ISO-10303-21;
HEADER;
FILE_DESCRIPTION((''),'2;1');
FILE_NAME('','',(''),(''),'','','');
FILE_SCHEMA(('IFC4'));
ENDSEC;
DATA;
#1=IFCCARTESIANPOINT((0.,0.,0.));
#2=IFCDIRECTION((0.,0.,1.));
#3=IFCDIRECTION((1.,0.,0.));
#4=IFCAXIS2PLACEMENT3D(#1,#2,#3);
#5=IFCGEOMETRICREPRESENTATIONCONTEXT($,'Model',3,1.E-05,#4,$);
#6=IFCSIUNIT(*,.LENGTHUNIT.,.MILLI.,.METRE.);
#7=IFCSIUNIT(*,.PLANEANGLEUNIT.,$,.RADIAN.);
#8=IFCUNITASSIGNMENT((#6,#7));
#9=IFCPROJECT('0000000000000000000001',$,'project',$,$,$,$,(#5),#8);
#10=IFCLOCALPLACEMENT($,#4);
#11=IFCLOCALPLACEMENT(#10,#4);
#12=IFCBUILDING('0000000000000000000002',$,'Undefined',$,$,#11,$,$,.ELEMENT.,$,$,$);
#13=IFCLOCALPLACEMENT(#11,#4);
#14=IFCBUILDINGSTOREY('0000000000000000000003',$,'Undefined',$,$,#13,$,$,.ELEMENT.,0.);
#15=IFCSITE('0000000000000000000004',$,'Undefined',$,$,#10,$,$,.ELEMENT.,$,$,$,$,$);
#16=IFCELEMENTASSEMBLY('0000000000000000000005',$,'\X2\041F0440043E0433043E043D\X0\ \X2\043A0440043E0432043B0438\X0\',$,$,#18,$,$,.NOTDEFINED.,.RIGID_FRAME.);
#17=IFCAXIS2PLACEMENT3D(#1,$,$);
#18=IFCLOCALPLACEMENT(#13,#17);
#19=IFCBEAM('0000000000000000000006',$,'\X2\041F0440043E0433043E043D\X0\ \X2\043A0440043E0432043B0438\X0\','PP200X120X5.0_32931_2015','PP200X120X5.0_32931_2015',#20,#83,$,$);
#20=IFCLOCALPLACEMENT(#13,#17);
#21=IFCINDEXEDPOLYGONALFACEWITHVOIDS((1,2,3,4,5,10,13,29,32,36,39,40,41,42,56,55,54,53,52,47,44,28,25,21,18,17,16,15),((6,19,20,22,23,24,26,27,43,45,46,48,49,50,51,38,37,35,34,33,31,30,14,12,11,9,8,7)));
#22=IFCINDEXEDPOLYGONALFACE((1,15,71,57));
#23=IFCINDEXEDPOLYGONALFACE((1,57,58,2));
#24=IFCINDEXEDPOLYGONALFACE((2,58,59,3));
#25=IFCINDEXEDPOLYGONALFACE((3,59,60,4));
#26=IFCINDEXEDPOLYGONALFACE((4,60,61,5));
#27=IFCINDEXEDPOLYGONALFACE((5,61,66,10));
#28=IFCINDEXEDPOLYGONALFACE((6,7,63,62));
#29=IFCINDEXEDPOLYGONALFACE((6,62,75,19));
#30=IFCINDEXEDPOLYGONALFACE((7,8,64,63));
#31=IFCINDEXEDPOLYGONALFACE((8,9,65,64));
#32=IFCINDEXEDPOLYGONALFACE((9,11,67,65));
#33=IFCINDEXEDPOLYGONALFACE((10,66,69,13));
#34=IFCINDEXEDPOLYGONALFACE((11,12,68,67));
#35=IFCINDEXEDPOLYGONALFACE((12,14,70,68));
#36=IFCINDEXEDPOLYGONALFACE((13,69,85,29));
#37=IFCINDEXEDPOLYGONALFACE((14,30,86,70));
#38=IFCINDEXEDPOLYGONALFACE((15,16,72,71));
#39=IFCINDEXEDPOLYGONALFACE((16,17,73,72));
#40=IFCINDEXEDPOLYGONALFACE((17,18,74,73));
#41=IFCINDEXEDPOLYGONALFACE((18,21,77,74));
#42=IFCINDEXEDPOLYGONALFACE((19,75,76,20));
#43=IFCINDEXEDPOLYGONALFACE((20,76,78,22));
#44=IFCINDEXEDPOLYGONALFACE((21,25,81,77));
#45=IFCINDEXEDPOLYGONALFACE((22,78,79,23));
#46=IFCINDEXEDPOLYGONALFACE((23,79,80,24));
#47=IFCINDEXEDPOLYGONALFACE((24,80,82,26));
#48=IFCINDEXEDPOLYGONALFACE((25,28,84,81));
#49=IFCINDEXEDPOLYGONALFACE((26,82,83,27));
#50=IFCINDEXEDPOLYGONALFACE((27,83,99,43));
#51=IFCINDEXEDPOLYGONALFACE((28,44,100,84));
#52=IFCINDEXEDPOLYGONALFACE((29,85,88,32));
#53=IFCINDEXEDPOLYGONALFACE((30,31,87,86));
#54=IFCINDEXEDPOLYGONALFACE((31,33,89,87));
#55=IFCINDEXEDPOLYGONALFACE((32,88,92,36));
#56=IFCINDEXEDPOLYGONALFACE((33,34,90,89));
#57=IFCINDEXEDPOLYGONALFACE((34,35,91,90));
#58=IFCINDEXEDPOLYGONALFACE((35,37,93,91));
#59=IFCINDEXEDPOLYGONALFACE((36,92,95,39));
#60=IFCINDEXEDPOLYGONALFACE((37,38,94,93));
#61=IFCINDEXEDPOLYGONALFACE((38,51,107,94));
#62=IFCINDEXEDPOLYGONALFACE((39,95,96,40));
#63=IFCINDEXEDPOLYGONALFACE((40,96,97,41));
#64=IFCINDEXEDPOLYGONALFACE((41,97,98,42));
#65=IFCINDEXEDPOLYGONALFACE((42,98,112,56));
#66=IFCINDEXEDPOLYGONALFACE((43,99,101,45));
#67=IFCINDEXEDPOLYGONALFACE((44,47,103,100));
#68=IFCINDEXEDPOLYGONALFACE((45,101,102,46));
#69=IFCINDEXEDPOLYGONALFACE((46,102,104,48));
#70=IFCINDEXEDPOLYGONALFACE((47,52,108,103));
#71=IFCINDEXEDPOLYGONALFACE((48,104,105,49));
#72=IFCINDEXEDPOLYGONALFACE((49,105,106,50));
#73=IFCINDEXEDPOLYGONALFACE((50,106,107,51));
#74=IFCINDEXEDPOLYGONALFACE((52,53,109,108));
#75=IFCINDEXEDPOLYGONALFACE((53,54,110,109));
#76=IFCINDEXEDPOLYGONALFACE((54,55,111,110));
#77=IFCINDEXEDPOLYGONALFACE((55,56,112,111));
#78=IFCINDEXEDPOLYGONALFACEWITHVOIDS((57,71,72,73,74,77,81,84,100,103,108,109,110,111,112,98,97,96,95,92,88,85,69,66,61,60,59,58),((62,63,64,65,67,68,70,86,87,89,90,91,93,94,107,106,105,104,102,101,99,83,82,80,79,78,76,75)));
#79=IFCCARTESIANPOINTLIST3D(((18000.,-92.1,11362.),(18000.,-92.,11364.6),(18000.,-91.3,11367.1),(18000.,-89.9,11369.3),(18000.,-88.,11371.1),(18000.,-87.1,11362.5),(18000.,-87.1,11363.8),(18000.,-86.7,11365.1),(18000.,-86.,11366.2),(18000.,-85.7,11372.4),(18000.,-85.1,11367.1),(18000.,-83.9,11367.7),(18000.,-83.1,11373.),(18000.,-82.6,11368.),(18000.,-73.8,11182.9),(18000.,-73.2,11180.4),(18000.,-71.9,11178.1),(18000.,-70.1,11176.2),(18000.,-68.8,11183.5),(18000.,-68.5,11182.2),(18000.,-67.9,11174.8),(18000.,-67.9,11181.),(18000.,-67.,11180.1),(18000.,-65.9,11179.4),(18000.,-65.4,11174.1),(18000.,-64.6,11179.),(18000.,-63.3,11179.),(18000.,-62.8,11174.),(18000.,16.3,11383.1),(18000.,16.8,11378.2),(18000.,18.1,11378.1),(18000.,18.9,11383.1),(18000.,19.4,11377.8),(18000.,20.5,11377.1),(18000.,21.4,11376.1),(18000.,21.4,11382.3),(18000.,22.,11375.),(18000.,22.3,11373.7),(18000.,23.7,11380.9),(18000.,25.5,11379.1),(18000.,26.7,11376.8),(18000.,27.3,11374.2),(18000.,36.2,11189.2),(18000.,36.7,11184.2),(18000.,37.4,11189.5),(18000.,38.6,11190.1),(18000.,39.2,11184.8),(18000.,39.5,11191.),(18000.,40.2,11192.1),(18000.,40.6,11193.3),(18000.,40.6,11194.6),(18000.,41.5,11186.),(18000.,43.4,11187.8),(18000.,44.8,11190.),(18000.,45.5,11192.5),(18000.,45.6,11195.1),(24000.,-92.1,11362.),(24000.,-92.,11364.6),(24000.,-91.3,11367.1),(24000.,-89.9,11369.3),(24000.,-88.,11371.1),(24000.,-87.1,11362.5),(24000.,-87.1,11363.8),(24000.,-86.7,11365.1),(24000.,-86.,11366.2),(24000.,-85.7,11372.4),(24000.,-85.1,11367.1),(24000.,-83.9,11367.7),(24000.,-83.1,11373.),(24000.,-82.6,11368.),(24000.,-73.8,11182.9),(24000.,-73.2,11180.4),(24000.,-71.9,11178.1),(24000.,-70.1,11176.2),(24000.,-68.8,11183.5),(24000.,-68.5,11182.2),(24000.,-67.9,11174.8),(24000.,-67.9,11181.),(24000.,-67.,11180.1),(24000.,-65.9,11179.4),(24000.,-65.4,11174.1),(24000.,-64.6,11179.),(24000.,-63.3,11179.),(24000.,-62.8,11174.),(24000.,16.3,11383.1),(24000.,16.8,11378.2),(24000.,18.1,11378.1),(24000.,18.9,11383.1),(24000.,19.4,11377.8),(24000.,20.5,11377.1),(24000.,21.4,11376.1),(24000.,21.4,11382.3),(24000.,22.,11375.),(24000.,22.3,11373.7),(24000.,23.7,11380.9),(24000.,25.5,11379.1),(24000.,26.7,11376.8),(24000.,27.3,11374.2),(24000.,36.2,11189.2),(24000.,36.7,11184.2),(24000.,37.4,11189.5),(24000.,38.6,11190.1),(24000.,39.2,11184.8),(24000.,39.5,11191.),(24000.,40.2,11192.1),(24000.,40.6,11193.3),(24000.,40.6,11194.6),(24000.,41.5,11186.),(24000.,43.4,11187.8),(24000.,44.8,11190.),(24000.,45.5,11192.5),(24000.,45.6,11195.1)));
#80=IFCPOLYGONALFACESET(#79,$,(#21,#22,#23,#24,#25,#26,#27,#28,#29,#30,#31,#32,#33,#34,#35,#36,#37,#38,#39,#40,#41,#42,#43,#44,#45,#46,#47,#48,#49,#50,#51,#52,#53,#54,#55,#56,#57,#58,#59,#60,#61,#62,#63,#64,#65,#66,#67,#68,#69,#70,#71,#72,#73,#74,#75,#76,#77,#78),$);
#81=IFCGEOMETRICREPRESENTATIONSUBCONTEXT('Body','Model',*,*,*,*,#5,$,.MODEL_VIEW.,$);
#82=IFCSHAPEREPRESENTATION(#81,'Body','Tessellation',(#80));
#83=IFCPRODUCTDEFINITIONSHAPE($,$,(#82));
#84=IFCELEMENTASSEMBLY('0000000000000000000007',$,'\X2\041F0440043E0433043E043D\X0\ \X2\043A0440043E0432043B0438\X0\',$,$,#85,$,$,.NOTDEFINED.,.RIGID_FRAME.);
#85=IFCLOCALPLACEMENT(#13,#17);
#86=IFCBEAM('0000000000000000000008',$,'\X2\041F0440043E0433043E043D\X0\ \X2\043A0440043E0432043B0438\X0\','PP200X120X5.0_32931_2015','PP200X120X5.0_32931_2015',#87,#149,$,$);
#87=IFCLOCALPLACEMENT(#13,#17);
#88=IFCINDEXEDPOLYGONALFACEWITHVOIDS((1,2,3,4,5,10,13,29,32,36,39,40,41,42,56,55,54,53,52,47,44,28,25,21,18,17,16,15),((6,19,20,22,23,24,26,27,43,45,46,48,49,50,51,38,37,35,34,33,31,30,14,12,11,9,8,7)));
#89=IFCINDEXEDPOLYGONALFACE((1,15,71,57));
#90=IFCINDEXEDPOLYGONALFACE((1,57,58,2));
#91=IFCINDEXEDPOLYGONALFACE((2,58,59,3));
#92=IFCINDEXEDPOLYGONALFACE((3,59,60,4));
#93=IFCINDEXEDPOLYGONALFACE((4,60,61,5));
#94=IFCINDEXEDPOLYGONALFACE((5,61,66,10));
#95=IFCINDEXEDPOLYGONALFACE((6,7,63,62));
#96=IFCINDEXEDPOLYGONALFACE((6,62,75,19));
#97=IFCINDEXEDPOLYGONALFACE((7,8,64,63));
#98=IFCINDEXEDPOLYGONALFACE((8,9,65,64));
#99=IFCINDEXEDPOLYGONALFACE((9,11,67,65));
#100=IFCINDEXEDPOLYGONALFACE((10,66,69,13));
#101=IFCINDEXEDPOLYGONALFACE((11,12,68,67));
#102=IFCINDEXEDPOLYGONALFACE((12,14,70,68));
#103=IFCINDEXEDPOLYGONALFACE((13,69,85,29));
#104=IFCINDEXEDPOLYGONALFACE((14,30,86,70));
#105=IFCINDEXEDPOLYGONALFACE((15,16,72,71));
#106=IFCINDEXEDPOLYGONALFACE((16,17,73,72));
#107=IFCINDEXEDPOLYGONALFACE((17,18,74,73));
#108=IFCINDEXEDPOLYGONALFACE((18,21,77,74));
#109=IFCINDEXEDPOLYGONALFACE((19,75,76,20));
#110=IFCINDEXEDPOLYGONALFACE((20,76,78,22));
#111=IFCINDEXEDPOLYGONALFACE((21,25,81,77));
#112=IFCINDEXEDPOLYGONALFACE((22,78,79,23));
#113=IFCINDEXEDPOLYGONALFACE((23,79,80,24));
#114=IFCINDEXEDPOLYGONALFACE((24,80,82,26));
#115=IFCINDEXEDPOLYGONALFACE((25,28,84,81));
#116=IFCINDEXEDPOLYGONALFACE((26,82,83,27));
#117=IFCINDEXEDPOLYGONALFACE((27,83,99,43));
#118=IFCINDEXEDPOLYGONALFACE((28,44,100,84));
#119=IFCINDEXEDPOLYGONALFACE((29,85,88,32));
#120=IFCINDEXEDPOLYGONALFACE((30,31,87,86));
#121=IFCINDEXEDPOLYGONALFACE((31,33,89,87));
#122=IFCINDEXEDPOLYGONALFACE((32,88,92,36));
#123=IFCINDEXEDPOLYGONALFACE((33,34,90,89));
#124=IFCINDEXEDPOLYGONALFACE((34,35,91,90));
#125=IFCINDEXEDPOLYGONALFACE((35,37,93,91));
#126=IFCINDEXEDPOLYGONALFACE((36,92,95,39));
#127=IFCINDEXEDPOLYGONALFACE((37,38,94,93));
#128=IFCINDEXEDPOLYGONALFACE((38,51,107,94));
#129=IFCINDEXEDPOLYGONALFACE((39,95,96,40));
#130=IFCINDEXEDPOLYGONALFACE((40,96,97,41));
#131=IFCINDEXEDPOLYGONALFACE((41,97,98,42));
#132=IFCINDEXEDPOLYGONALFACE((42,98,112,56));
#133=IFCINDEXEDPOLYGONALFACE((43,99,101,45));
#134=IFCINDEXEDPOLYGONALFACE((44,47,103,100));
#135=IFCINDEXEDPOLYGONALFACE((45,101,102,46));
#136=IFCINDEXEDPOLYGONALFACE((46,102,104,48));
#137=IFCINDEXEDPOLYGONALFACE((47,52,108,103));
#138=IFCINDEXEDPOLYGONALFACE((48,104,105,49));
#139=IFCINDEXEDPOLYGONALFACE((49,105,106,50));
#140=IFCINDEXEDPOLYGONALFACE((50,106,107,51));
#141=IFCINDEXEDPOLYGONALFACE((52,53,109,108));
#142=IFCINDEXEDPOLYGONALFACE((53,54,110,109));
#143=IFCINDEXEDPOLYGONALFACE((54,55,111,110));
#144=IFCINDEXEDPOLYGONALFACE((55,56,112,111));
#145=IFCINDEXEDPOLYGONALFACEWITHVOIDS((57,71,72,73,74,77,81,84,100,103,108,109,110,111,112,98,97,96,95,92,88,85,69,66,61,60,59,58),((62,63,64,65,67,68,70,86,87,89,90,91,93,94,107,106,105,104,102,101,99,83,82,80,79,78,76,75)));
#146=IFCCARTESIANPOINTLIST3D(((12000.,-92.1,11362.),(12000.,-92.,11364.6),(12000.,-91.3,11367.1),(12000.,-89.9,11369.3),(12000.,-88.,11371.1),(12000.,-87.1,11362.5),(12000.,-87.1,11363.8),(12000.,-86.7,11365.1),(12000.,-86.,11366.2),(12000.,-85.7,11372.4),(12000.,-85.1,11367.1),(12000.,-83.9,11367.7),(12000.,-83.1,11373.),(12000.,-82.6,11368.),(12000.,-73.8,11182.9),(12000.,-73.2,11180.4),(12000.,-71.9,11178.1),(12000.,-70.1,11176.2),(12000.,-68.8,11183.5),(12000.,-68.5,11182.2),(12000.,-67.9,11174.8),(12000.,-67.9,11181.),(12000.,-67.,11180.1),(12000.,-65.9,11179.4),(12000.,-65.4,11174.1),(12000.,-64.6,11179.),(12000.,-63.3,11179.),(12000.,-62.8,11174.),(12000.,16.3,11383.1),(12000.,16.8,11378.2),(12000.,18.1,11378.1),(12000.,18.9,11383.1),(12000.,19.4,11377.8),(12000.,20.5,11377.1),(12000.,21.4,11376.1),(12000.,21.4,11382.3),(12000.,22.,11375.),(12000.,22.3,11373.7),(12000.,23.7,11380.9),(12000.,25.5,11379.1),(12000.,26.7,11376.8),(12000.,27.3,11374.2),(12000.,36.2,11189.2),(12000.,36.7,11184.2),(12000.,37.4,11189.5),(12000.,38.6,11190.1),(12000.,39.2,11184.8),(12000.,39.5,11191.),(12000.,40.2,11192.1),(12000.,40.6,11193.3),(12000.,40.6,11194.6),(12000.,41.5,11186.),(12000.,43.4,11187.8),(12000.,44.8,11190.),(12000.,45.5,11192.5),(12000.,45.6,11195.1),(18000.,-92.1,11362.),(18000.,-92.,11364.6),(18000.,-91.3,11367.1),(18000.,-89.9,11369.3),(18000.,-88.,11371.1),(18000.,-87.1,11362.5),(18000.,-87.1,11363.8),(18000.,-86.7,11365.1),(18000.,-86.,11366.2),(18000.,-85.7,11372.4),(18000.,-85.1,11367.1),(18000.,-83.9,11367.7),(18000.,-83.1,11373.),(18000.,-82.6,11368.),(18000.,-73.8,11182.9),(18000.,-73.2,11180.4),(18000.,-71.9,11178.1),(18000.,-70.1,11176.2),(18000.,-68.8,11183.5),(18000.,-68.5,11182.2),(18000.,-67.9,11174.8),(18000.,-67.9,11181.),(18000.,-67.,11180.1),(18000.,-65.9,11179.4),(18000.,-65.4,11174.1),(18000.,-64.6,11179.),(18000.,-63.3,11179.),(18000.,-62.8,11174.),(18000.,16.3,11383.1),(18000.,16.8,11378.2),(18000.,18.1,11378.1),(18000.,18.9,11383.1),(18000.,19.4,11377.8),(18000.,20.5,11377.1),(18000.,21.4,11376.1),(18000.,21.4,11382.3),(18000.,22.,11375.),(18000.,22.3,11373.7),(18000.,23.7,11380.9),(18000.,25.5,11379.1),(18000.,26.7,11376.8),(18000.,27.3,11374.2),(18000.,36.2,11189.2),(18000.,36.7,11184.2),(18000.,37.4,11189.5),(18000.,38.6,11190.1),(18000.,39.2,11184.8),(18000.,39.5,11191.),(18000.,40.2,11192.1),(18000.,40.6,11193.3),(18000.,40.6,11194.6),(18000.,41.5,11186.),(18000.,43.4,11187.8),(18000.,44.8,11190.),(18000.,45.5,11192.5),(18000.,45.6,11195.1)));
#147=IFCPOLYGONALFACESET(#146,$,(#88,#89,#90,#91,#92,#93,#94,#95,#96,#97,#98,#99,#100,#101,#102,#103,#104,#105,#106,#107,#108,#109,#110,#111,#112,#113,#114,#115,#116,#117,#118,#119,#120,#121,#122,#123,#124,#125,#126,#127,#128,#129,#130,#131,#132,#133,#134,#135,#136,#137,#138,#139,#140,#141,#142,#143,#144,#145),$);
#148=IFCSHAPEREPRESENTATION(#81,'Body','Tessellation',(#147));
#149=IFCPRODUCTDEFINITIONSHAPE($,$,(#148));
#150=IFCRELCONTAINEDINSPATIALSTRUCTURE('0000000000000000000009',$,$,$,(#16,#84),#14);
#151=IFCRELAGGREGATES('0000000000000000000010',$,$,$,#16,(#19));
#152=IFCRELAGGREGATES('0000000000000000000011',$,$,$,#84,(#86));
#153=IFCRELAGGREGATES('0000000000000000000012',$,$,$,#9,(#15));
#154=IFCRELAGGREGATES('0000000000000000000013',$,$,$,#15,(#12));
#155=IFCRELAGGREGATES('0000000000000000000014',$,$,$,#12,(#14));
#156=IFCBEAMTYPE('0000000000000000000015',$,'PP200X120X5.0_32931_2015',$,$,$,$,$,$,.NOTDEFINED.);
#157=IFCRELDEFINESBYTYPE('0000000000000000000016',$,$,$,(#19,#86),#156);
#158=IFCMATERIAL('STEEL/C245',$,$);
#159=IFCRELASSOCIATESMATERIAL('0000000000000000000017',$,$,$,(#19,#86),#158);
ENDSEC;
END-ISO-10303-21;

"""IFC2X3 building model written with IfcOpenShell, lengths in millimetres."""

from ifc_helpers import new_model, si_unit, frame, origin_with_axes, origin_2d_with_axis, place, context, subcontext, project, spatial, hollow_rectangle, extrude, material, type_object, element, aggregate, save


model = new_model("IFC2X3")

# Units and contexts
model_context = context("Model", 3, precision=1e-05, world=origin_with_axes())
body_context = subcontext(model_context, "Body", "Model", "MODEL_VIEW")
ifc_project = project(units=[si_unit("LENGTHUNIT", "METRE", prefix="MILLI"), si_unit("PLANEANGLEUNIT", "RADIAN")], contexts=[model_context])

# Site, building, storey
site_placement = place(None, origin_with_axes())
site = spatial("IfcSite", under=ifc_project, at=site_placement, Name="Undefined", CompositionType="ELEMENT")
building_placement = place(site_placement, origin_with_axes())
building = spatial("IfcBuilding", under=site, at=building_placement, Name="Undefined", CompositionType="ELEMENT")
storey_placement = place(building_placement, origin_with_axes())
storey = spatial("IfcBuildingStorey", under=building, at=storey_placement, Name="Undefined", CompositionType="ELEMENT", Elevation=0.0)

# Element assemblies, beams
ifc_material_1 = material(Name="STEEL/C245")
beam_type_1 = type_object("IfcBeamType", Name="PP200X120X5.0_32931_2015", PredefinedType="NOTDEFINED")
assembly_1_placement = place(storey_placement, origin_with_axes())
assembly_1 = element("IfcElementAssembly", 1, at=assembly_1_placement, inside=storey, Name="Прогон кровли", AssemblyPlace="NOTDEFINED", PredefinedType="RIGID_FRAME")
beam_1_placement = place(assembly_1_placement, frame((24000.0, -23.2, 11278.6), z_axis=(0.0, -0.101645, 0.994821), x_axis=(-1.0, 0.0, 0.0)))
beam_1 = element("IfcBeam", 2, at=beam_1_placement, type_object=beam_type_1, material=ifc_material_1, Name="Прогон кровли", Description="PP200X120X5.0_32931_2015", ObjectType="PP200X120X5.0_32931_2015", context=body_context, shape_type="SweptSolid", body=[
    extrude(hollow_rectangle(XDim=120.0, YDim=200.0, WallThickness=5.0, InnerFilletRadius=5.0, OuterFilletRadius=10.0, at=origin_2d_with_axis()), frame((6000.0, 0.0, 0.0), z_axis=(-1.0, 0.0, 0.0), x_axis=(0.0, -1.0, 0.0)), (0.0, 0.0, 1.0), 6000.0),
])
aggregate(assembly_1, [beam_1])
assembly_2_placement = place(storey_placement, origin_with_axes())
assembly_2 = element("IfcElementAssembly", 3, at=assembly_2_placement, inside=storey, Name="Прогон кровли", AssemblyPlace="NOTDEFINED", PredefinedType="RIGID_FRAME")
beam_2_placement = place(assembly_2_placement, frame((18000.0, -23.2, 11278.6), z_axis=(0.0, -0.101645, 0.994821), x_axis=(-1.0, 0.0, 0.0)))
beam_2 = element("IfcBeam", 4, at=beam_2_placement, type_object=beam_type_1, material=ifc_material_1, Name="Прогон кровли", Description="PP200X120X5.0_32931_2015", ObjectType="PP200X120X5.0_32931_2015", context=body_context, shape_type="SweptSolid", body=[
    extrude(hollow_rectangle(XDim=120.0, YDim=200.0, WallThickness=5.0, InnerFilletRadius=5.0, OuterFilletRadius=10.0, at=origin_2d_with_axis()), frame((6000.0, 0.0, 0.0), z_axis=(-1.0, 0.0, 0.0), x_axis=(0.0, -1.0, 0.0)), (0.0, 0.0, 1.0), 6000.0),
])
aggregate(assembly_2, [beam_2])

save(model, "model.ifc")
